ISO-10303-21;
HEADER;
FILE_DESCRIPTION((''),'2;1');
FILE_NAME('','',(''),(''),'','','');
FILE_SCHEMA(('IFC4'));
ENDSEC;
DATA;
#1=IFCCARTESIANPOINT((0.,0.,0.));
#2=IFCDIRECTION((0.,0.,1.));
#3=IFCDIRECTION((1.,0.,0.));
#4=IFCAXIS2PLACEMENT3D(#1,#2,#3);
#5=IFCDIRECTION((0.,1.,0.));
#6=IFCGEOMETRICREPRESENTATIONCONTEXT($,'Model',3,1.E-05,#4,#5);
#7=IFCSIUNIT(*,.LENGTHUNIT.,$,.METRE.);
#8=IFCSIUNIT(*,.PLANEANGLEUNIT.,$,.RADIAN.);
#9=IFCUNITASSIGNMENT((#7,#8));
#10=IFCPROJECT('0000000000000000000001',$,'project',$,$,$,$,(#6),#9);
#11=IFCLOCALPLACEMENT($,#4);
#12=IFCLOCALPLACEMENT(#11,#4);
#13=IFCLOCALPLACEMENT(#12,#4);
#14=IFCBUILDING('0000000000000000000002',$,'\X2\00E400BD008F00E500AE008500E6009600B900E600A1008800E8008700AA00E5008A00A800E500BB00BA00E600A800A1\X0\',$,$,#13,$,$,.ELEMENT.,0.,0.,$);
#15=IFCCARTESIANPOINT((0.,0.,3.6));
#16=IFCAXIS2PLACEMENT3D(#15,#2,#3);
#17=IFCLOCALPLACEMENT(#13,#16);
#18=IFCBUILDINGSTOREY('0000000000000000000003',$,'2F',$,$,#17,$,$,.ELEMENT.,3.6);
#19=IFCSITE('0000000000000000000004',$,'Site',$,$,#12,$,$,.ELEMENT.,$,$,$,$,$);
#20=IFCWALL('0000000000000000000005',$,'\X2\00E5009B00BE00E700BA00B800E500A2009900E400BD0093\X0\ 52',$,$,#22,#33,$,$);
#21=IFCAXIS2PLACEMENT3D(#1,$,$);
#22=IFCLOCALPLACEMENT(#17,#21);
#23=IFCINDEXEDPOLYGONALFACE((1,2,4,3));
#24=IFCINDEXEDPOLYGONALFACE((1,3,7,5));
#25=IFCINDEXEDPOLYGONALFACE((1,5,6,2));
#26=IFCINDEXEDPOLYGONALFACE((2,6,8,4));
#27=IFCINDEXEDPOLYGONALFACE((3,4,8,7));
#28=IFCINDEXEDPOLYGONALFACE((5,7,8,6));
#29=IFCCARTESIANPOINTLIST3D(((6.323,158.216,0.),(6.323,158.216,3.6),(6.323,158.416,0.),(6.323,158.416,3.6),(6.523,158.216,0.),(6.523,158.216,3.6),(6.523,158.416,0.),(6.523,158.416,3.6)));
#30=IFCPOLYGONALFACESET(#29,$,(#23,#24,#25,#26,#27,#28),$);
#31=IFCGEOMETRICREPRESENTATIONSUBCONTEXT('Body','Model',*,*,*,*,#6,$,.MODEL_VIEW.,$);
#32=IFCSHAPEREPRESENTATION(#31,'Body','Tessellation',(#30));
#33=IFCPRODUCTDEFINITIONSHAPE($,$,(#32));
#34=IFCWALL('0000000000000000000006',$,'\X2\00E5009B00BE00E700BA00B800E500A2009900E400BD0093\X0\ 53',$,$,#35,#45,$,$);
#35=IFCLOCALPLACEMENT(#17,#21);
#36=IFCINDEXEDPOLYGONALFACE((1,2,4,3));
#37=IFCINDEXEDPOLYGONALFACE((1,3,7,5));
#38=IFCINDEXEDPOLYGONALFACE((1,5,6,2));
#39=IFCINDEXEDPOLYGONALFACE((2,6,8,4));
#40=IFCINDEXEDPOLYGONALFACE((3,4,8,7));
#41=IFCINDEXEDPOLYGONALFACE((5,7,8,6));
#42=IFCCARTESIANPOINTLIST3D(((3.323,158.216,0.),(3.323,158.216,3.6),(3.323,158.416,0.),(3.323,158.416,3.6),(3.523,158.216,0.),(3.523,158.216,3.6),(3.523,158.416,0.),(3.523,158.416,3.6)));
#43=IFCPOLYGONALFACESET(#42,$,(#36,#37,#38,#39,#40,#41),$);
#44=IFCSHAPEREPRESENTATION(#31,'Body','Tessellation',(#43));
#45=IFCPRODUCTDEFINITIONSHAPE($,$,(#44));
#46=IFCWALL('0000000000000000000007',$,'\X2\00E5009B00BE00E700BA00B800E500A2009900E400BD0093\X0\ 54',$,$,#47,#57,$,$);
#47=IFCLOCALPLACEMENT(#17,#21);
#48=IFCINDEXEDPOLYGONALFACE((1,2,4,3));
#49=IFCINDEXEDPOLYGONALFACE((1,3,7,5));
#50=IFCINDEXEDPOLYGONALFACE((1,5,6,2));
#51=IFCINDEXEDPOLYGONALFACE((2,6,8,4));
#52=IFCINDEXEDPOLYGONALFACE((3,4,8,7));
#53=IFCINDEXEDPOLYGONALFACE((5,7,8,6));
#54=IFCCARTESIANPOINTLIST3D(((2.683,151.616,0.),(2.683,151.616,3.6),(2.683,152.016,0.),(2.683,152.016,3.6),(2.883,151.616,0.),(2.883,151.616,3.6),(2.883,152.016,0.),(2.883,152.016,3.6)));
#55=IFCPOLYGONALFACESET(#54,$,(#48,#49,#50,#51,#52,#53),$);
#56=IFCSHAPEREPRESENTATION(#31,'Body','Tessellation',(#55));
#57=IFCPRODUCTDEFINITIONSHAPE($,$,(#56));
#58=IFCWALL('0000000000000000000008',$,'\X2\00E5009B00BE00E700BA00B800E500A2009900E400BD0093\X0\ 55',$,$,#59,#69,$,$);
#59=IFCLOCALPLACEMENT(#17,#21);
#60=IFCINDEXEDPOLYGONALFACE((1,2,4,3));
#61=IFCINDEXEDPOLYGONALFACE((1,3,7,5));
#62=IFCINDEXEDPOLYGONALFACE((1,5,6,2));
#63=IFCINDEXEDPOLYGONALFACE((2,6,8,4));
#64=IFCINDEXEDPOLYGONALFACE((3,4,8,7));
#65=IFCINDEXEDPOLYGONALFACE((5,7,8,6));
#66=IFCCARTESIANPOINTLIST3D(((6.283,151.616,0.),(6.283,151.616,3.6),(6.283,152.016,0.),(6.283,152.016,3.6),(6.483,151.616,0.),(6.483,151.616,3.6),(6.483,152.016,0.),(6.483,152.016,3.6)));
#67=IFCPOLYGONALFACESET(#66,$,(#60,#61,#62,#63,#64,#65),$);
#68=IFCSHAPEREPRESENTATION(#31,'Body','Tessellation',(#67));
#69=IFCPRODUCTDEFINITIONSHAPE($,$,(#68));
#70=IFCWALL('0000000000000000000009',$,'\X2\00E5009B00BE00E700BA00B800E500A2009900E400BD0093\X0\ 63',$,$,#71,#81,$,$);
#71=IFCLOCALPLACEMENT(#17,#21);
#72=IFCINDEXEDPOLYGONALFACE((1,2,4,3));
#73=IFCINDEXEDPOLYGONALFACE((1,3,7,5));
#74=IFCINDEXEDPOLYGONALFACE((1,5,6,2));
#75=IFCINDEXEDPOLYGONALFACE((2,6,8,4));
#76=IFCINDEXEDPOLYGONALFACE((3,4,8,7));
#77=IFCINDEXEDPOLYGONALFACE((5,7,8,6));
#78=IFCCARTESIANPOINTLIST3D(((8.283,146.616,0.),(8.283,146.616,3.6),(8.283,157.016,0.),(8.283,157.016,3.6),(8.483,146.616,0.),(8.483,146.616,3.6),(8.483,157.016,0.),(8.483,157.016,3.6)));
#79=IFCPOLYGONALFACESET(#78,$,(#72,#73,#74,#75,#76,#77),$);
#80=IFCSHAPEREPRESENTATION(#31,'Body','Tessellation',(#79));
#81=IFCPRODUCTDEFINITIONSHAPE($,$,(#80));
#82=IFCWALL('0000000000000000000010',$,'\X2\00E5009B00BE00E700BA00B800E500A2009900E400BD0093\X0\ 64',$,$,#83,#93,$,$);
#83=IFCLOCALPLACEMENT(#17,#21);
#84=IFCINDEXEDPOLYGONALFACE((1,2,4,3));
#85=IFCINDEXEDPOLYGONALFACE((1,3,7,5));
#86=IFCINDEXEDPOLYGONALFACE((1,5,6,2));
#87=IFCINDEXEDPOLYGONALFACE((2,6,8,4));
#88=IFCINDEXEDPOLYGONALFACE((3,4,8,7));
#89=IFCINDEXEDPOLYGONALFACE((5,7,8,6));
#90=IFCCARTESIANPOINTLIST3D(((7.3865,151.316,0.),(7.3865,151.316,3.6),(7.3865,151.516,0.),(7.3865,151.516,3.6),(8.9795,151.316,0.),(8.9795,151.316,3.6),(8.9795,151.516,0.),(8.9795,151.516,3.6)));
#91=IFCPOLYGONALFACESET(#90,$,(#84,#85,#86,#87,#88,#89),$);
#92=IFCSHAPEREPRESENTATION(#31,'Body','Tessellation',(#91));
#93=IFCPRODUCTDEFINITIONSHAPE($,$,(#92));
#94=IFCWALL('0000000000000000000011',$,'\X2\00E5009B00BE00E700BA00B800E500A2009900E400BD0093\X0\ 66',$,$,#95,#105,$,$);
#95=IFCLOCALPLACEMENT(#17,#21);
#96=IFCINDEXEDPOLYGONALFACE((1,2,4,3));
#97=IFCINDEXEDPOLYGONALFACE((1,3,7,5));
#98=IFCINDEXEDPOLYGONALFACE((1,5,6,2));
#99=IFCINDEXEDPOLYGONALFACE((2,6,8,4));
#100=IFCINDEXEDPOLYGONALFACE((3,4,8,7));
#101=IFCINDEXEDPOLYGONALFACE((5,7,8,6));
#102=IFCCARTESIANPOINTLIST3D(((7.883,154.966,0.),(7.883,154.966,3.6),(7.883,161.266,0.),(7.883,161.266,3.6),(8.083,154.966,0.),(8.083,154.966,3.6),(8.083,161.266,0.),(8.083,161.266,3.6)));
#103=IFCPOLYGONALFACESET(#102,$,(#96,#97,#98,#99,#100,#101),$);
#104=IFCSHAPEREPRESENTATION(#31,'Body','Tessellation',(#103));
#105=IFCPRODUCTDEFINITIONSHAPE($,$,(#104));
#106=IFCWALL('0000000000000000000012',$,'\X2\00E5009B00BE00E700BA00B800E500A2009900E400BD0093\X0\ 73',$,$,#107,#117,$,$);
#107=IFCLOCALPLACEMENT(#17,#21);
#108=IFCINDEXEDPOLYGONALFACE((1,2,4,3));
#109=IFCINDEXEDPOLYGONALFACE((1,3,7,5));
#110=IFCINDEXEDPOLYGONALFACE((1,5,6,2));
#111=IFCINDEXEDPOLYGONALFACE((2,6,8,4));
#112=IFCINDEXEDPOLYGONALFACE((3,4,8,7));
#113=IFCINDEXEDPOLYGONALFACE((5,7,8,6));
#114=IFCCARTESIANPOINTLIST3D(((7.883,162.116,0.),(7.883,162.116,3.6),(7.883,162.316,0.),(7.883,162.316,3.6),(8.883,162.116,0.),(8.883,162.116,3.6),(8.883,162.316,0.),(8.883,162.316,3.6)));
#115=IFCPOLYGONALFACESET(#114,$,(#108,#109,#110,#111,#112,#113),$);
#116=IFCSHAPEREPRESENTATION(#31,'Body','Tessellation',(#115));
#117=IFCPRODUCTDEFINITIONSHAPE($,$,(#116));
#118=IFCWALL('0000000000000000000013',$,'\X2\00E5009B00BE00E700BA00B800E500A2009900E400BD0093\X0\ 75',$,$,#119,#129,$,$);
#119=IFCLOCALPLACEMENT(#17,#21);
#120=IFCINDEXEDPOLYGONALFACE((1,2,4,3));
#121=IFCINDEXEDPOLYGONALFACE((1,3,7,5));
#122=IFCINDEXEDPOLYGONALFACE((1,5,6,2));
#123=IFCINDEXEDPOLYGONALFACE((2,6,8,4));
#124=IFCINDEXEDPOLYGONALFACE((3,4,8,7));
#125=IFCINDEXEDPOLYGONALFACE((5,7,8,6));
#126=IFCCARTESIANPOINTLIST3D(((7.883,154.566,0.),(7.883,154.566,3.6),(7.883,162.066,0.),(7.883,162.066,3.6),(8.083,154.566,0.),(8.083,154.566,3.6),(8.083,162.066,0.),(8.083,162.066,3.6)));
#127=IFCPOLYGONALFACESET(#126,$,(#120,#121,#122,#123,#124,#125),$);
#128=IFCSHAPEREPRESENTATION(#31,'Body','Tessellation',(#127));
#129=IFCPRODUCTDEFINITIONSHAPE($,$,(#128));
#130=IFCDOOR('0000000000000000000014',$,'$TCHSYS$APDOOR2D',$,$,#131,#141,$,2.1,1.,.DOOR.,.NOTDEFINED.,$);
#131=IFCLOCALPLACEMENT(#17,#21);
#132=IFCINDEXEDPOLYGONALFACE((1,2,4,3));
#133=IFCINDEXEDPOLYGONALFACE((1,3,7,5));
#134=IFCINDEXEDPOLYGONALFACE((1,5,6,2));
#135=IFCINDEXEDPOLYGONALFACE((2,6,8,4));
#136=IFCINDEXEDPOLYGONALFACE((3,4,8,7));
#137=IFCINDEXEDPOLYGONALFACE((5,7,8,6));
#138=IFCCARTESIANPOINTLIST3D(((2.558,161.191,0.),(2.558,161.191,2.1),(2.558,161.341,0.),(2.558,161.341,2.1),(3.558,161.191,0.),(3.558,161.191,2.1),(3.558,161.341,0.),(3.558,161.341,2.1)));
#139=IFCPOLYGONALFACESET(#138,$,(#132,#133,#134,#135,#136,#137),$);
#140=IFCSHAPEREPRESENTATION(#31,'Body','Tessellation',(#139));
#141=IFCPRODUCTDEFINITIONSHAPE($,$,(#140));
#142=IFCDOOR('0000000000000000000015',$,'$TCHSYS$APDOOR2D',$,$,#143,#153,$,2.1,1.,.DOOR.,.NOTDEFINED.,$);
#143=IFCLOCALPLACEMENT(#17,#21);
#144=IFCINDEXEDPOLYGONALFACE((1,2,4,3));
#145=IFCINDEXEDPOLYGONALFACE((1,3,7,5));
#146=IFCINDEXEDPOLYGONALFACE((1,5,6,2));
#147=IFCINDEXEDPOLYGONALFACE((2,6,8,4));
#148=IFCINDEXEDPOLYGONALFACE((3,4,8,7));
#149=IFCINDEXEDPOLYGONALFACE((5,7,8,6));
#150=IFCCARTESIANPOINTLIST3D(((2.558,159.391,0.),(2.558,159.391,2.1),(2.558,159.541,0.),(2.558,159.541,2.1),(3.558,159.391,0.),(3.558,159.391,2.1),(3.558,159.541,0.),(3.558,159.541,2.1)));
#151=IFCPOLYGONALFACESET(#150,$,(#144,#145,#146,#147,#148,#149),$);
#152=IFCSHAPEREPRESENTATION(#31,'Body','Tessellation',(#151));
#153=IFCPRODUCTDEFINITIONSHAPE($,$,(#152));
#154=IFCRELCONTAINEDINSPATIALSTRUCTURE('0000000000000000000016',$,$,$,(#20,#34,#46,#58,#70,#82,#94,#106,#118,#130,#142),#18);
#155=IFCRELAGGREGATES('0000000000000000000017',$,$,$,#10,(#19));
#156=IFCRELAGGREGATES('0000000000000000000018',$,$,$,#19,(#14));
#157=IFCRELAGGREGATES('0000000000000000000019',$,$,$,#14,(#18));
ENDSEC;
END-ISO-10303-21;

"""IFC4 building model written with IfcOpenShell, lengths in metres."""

from ifc_helpers import new_model, si_unit, direction, frame, frame_2d, origin_with_axes, place, context, subcontext, project, spatial, rectangle, extrude, element, save


model = new_model("IFC4")

# Units and contexts
model_context = context("Model", 3, precision=1e-05, world=origin_with_axes(), true_north=direction((0.0, 1.0, 0.0)))
body_context = subcontext(model_context, "Body", "Model", "MODEL_VIEW")
ifc_project = project(units=[si_unit("LENGTHUNIT", "METRE"), si_unit("PLANEANGLEUNIT", "RADIAN")], contexts=[model_context])

# Site, building, storey
placement = place(None, origin_with_axes())
site_placement = place(placement, origin_with_axes())
site = spatial("IfcSite", under=ifc_project, at=site_placement, Name="Site", CompositionType="ELEMENT")
building_placement = place(site_placement, origin_with_axes())
building = spatial("IfcBuilding", under=site, at=building_placement, Name="ä½\u008få®\u0085æ\u0096¹æ¡\u0088è\u0087ªå\u008a¨å»ºæ¨¡", CompositionType="ELEMENT", ElevationOfRefHeight=0.0, ElevationOfTerrain=0.0)
storey_placement = place(building_placement, frame((0.0, 0.0, 3.6), z_axis=(0.0, 0.0, 1.0), x_axis=(1.0, 0.0, 0.0)))
storey = spatial("IfcBuildingStorey", under=building, at=storey_placement, Name="2F", CompositionType="ELEMENT", Elevation=3.6)

# Walls
for number, where, z_axis, x_axis, name in (
    (1, (6.423, 158.316, 0.0), (0.0, 0.0, 1.0), (0.0, -1.0, 0.0), "å\u009b¾çº¸å¢\u0099ä½\u0093 52"),
    (2, (3.423, 158.316, 0.0), (0.0, 0.0, 1.0), (0.0, -1.0, 0.0), "å\u009b¾çº¸å¢\u0099ä½\u0093 53"),
):
    element("IfcWall", number, at=place(storey_placement, frame(where, z_axis=z_axis, x_axis=x_axis)), inside=storey, Name=name, context=body_context, shape_type="SweptSolid", body=[
        extrude(rectangle(XDim=0.2, YDim=0.2, at=frame_2d((0.0, 0.0), x_axis=(1.0, 0.0, 0.0))), frame((0.0, 0.0, 0.0), z_axis=(0.0, 0.0, 1.0)), (0.0, 0.0, 1.0), 3.6),
    ])
for number, where, z_axis, x_axis, name in (
    (3, (2.783, 151.816, 0.0), (0.0, 0.0, 1.0), (0.0, -1.0, 0.0), "å\u009b¾çº¸å¢\u0099ä½\u0093 54"),
    (4, (6.383, 151.816, 0.0), (0.0, 0.0, 1.0), (0.0, -1.0, 0.0), "å\u009b¾çº¸å¢\u0099ä½\u0093 55"),
):
    element("IfcWall", number, at=place(storey_placement, frame(where, z_axis=z_axis, x_axis=x_axis)), inside=storey, Name=name, context=body_context, shape_type="SweptSolid", body=[
        extrude(rectangle(XDim=0.4, YDim=0.2, at=frame_2d((0.0, 0.0), x_axis=(1.0, 0.0, 0.0))), frame((0.0, 0.0, 0.0), z_axis=(0.0, 0.0, 1.0)), (0.0, 0.0, 1.0), 3.6),
    ])
wall_1_placement = place(storey_placement, frame((8.383, 151.816, 0.0), z_axis=(0.0, 0.0, 1.0), x_axis=(0.0, 1.0, 0.0)))
element("IfcWall", 5, at=wall_1_placement, inside=storey, Name="å\u009b¾çº¸å¢\u0099ä½\u0093 63", context=body_context, shape_type="SweptSolid", body=[
    extrude(rectangle(XDim=10.4, YDim=0.2, at=frame_2d((0.0, 0.0), x_axis=(1.0, 0.0, 0.0))), frame((0.0, 0.0, 0.0), z_axis=(0.0, 0.0, 1.0)), (0.0, 0.0, 1.0), 3.6),
])
wall_2_placement = place(storey_placement, frame((8.183, 151.416, 0.0), z_axis=(0.0, 0.0, 1.0), x_axis=(1.0, 0.0, 0.0)))
element("IfcWall", 6, at=wall_2_placement, inside=storey, Name="å\u009b¾çº¸å¢\u0099ä½\u0093 64", context=body_context, shape_type="SweptSolid", body=[
    extrude(rectangle(XDim=1.593, YDim=0.2, at=frame_2d((0.0, 0.0), x_axis=(1.0, 0.0, 0.0))), frame((0.0, 0.0, 0.0), z_axis=(0.0, 0.0, 1.0)), (0.0, 0.0, 1.0), 3.6),
])
wall_3_placement = place(storey_placement, frame((7.983, 158.116, 0.0), z_axis=(0.0, 0.0, 1.0), x_axis=(0.0, -1.0, 0.0)))
element("IfcWall", 7, at=wall_3_placement, inside=storey, Name="å\u009b¾çº¸å¢\u0099ä½\u0093 66", context=body_context, shape_type="SweptSolid", body=[
    extrude(rectangle(XDim=6.3, YDim=0.2, at=frame_2d((0.0, 0.0), x_axis=(1.0, 0.0, 0.0))), frame((0.0, 0.0, 0.0), z_axis=(0.0, 0.0, 1.0)), (0.0, 0.0, 1.0), 3.6),
])
wall_4_placement = place(storey_placement, frame((8.383, 162.216, 0.0), z_axis=(0.0, 0.0, 1.0), x_axis=(1.0, 0.0, 0.0)))
element("IfcWall", 8, at=wall_4_placement, inside=storey, Name="å\u009b¾çº¸å¢\u0099ä½\u0093 73", context=body_context, shape_type="SweptSolid", body=[
    extrude(rectangle(XDim=1.0, YDim=0.2, at=frame_2d((0.0, 0.0), x_axis=(1.0, 0.0, 0.0))), frame((0.0, 0.0, 0.0), z_axis=(0.0, 0.0, 1.0)), (0.0, 0.0, 1.0), 3.6),
])
wall_5_placement = place(storey_placement, frame((7.983, 158.316, 0.0), z_axis=(0.0, 0.0, 1.0), x_axis=(0.0, 1.0, 0.0)))
element("IfcWall", 9, at=wall_5_placement, inside=storey, Name="å\u009b¾çº¸å¢\u0099ä½\u0093 75", context=body_context, shape_type="SweptSolid", body=[
    extrude(rectangle(XDim=7.5, YDim=0.2, at=frame_2d((0.0, 0.0), x_axis=(1.0, 0.0, 0.0))), frame((0.0, 0.0, 0.0), z_axis=(0.0, 0.0, 1.0)), (0.0, 0.0, 1.0), 3.6),
])

# Doors
for number, where, z_axis, x_axis, name in (
    (10, (3.058, 161.266, 0.0), (0.0, 0.0, 1.0), (1.0, 0.0, 0.0), "$TCHSYS$APDOOR2D"),
    (11, (3.058, 159.466, 0.0), (0.0, 0.0, 1.0), (1.0, 0.0, 0.0), "$TCHSYS$APDOOR2D"),
):
    element("IfcDoor", number, at=place(storey_placement, frame(where, z_axis=z_axis, x_axis=x_axis)), inside=storey, Name=name, OperationType="NOTDEFINED", OverallHeight=2.1, OverallWidth=1.0, PredefinedType="DOOR", context=body_context, shape_type="SweptSolid", body=[
        extrude(rectangle(XDim=1.0, YDim=0.15, at=frame_2d((0.0, 0.0), x_axis=(1.0, 0.0, 0.0))), frame((0.0, 0.0, 0.0), z_axis=(0.0, 0.0, 1.0)), (0.0, 0.0, 1.0), 2.1),
    ])

save(model, "model.ifc")
